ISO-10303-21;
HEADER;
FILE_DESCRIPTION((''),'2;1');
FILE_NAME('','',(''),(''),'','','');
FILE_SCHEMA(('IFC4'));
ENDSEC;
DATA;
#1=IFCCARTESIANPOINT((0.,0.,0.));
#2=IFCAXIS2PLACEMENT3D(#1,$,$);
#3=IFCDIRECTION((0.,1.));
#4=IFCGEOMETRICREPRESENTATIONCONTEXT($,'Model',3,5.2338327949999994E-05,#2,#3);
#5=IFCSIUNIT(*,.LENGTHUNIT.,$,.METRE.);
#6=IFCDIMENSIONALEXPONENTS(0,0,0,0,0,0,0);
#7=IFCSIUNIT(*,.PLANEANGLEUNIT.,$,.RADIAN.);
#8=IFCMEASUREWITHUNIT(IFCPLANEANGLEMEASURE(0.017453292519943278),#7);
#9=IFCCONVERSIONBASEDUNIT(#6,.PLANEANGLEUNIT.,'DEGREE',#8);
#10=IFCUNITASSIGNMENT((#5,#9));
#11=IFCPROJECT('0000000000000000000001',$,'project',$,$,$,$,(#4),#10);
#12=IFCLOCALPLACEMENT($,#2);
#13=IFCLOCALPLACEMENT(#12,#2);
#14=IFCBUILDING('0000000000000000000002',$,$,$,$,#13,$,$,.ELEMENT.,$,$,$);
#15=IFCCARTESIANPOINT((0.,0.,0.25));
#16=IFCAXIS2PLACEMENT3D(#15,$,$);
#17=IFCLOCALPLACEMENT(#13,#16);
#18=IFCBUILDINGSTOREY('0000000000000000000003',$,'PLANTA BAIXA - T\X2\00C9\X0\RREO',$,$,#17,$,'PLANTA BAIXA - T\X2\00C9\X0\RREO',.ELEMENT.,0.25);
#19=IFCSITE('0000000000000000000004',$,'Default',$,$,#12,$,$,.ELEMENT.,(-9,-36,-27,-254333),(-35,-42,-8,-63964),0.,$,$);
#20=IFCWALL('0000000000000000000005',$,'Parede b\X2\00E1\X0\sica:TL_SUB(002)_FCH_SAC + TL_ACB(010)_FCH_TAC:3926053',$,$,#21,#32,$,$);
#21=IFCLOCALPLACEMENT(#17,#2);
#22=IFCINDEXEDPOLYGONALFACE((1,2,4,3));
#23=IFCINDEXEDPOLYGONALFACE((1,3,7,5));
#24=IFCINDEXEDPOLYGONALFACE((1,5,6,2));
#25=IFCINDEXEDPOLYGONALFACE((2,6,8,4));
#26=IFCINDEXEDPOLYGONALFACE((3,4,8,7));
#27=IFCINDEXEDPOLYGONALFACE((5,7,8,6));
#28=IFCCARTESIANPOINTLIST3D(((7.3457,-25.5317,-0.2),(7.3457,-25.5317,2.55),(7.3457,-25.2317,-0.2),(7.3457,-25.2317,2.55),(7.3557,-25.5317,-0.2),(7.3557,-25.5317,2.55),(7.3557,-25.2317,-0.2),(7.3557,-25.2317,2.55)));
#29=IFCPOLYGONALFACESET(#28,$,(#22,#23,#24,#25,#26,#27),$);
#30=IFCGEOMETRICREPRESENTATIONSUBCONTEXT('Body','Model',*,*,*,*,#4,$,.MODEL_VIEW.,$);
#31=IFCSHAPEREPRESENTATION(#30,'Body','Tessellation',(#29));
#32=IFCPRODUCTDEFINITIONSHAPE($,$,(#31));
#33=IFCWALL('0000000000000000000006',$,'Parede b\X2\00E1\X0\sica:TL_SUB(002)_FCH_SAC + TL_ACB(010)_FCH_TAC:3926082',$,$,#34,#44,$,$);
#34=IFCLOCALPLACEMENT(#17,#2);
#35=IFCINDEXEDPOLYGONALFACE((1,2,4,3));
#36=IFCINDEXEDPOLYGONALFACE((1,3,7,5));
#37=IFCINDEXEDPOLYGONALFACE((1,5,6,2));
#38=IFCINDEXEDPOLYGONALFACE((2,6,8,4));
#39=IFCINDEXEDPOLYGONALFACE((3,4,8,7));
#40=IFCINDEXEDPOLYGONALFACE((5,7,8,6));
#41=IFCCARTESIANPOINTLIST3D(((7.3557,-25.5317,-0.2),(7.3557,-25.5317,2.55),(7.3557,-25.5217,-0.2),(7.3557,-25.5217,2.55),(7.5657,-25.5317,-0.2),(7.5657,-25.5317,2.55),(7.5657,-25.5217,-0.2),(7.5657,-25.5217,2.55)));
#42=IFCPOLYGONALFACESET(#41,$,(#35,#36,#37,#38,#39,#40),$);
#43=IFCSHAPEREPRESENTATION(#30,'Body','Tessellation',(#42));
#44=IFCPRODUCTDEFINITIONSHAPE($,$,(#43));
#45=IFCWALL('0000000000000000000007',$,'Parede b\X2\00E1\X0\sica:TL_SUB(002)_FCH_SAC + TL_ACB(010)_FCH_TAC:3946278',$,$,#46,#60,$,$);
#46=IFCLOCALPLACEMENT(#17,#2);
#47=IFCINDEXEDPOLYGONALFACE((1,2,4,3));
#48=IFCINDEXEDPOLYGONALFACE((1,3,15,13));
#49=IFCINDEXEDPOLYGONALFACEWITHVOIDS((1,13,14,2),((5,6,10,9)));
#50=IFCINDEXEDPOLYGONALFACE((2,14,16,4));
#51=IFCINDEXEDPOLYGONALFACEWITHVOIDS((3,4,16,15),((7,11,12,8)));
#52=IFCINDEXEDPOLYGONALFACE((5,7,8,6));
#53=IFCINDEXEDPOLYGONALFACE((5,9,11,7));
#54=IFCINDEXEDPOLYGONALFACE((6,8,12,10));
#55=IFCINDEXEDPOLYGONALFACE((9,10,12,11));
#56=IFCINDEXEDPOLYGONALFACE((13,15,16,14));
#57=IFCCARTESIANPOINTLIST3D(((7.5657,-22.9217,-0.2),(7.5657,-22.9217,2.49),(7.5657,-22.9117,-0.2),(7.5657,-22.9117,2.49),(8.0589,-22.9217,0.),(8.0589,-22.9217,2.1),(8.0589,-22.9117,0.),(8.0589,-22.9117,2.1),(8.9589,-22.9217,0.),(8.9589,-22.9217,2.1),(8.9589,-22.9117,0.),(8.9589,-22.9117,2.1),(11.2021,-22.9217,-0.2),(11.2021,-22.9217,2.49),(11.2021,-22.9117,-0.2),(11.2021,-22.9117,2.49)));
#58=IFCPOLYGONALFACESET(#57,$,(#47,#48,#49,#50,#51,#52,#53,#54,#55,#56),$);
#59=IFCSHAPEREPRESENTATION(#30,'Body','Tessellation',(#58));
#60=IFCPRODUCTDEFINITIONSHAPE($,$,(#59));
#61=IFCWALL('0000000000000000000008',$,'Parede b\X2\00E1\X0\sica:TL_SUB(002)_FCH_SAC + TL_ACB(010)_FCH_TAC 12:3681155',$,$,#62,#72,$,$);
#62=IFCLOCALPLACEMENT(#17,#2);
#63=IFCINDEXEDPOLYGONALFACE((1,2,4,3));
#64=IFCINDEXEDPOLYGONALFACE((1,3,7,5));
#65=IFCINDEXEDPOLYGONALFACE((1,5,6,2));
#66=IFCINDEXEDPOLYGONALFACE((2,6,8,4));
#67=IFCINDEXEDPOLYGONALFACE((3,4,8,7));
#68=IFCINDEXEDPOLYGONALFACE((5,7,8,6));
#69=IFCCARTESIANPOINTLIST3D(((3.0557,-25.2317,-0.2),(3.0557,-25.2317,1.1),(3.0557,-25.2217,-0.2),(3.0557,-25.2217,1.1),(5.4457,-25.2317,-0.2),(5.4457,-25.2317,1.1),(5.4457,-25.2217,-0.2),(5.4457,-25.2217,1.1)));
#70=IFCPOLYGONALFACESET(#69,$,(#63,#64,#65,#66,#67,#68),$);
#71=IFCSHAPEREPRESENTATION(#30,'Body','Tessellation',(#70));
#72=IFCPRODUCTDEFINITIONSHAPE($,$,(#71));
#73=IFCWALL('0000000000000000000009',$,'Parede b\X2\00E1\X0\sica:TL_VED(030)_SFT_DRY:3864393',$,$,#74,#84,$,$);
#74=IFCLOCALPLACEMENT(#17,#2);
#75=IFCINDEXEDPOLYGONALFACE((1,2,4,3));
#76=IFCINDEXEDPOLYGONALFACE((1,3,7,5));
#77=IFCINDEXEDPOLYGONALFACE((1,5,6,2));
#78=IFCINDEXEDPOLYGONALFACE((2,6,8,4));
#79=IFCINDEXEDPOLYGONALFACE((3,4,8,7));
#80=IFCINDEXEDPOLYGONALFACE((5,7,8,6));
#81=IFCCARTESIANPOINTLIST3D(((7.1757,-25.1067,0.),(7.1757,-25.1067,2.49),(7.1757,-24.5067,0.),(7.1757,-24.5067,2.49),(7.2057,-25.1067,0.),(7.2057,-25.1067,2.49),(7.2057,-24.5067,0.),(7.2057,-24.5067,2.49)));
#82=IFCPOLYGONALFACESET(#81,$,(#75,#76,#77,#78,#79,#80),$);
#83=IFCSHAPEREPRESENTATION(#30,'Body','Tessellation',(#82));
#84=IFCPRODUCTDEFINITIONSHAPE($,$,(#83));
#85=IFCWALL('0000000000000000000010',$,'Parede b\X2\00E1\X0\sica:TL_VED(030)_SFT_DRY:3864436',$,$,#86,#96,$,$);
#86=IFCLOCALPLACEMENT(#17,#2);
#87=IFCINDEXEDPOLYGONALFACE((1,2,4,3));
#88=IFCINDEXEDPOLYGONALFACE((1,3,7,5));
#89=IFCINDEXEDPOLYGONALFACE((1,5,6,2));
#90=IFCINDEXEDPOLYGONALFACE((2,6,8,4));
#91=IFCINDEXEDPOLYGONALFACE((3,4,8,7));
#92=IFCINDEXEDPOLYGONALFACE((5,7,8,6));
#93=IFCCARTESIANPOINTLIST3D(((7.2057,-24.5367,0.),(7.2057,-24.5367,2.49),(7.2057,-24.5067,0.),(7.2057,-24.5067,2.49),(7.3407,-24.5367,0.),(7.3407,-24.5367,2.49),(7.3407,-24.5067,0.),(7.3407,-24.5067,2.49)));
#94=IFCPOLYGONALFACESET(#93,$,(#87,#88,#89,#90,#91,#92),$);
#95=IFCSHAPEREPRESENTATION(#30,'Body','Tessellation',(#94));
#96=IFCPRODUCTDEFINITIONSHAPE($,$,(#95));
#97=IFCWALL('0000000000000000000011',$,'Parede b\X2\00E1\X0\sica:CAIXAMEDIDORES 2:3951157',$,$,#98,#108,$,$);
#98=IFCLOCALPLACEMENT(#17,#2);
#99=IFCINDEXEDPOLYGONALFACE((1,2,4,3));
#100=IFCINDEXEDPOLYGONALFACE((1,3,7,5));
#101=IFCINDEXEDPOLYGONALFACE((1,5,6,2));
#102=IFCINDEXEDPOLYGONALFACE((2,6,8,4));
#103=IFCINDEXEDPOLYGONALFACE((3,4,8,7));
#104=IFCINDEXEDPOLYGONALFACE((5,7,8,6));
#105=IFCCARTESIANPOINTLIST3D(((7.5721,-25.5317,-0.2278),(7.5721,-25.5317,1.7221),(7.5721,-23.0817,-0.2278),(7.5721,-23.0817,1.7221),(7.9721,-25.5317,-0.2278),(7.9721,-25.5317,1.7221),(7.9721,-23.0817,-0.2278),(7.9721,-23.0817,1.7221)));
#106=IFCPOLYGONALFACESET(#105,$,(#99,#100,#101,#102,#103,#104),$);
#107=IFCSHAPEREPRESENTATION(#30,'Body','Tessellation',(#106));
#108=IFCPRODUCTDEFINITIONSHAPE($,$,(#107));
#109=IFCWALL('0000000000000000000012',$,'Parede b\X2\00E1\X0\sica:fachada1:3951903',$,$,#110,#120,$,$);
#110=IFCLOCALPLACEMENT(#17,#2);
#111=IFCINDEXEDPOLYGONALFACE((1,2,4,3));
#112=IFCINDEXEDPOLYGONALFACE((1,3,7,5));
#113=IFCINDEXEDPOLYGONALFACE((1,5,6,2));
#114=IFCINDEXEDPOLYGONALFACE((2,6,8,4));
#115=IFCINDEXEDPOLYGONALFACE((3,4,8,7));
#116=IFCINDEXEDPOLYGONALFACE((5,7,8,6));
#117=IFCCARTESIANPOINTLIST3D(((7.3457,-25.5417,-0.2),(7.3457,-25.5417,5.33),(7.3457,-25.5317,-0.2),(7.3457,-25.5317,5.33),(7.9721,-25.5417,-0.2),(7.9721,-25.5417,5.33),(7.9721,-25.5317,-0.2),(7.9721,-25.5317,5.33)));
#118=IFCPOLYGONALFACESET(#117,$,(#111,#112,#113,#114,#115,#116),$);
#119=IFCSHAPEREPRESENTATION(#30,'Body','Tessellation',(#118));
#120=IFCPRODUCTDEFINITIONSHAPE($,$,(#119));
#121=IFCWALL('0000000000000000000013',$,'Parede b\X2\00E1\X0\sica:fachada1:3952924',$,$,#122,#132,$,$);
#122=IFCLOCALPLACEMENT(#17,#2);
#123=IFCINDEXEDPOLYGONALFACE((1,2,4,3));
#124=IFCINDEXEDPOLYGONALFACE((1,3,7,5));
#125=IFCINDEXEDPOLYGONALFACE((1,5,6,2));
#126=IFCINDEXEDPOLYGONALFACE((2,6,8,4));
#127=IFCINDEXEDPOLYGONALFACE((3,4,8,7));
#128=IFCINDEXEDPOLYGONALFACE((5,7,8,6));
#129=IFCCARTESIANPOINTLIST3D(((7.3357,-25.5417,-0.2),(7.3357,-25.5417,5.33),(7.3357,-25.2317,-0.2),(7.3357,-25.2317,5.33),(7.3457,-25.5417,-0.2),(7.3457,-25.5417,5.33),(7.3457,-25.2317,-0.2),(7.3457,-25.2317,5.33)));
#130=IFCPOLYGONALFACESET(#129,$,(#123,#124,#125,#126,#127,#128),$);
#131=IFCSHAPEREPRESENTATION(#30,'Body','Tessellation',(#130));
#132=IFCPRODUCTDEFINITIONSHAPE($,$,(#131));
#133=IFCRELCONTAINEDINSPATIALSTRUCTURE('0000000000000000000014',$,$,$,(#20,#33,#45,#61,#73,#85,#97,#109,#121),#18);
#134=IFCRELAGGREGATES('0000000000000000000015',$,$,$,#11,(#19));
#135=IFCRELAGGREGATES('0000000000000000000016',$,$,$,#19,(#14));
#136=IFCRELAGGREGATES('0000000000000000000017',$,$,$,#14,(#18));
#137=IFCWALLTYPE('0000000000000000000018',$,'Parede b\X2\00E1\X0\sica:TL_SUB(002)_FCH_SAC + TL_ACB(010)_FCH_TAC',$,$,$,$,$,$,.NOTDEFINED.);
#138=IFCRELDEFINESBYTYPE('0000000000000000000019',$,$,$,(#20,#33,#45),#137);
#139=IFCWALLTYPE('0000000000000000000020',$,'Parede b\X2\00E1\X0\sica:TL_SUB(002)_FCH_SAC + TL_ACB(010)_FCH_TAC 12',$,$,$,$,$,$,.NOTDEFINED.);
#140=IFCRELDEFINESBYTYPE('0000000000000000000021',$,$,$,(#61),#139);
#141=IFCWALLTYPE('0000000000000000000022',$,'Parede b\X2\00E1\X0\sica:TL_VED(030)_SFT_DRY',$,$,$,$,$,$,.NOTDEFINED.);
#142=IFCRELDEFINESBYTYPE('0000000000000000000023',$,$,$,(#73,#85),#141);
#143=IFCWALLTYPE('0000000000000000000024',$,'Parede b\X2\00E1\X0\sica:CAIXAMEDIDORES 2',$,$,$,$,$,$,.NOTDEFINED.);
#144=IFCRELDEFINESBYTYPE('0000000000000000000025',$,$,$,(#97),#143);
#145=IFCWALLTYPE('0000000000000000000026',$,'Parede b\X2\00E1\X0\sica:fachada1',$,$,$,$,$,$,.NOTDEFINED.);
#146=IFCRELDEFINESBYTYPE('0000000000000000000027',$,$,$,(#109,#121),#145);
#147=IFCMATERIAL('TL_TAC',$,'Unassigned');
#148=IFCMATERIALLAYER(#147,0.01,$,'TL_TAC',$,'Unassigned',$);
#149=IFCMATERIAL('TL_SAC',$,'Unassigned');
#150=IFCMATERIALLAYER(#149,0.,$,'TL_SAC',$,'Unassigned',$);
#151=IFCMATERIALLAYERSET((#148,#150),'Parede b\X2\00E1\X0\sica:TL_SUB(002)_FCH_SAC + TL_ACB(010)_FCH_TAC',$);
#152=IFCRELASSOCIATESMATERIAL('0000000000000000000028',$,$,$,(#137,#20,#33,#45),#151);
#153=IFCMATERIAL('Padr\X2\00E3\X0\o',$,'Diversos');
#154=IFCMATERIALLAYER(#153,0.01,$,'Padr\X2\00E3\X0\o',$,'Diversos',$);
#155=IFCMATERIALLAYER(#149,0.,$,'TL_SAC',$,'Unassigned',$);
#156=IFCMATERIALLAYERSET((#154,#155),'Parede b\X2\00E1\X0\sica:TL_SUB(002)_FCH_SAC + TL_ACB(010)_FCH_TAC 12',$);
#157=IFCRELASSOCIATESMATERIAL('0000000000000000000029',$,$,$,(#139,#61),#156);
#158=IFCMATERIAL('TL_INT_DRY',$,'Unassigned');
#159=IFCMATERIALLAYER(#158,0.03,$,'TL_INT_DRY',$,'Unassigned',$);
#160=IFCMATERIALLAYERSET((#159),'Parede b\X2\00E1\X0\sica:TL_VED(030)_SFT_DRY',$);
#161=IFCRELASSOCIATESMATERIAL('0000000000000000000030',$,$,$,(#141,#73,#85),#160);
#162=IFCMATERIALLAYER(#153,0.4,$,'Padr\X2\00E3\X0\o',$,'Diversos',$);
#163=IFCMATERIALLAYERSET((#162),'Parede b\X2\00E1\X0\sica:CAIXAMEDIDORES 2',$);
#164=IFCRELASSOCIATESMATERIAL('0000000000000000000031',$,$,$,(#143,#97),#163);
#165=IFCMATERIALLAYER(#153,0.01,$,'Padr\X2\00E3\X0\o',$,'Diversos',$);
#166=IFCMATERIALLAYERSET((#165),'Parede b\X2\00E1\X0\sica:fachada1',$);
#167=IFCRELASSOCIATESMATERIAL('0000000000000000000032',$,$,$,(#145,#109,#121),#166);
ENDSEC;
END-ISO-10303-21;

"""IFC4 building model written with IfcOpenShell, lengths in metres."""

from ifc_helpers import new_model, entity, si_unit, converted_unit, direction, frame, frame_2d, origin, place, context, subcontext, project, spatial, polyline, rectangle, extrude, clip, bounded_halfspace, material, layer, layer_set, layer_usage, type_object, element, save


model = new_model("IFC4")

# Units and contexts
model_context = context("Model", 3, precision=5.2338327949999994e-05, world=origin(), true_north=direction((0.0, 1.0)))
body_context = subcontext(model_context, "Body", "Model", "MODEL_VIEW")
ifc_project = project(units=[si_unit("LENGTHUNIT", "METRE"), converted_unit("PLANEANGLEUNIT", "DEGREE", entity("IfcPlaneAngleMeasure", 0.017453292519943278), si_unit("PLANEANGLEUNIT", "RADIAN"), dimensions=[0, 0, 0, 0, 0, 0, 0])], contexts=[model_context])

# Site, building, storey
site_placement = place(None, frame((0.0, 0.0, 0.0)))
site = spatial("IfcSite", under=ifc_project, at=site_placement, Name="Default", CompositionType="ELEMENT", RefLatitude=(-9, -36, -27, -254333), RefLongitude=(-35, -42, -8, -63964), RefElevation=0.0)
building_placement = place(site_placement, origin())
building = spatial("IfcBuilding", under=site, at=building_placement, CompositionType="ELEMENT")
storey_placement = place(building_placement, frame((0.0, 0.0, 0.25)))
storey = spatial("IfcBuildingStorey", under=building, at=storey_placement, Name="PLANTA BAIXA - TÉRREO", LongName="PLANTA BAIXA - TÉRREO", CompositionType="ELEMENT", Elevation=0.25)

# Shared definitions
ifc_material_1 = material(Name="TL_SAC", Category="Unassigned")

# Shared definitions
ifc_material_2 = material(Name="TL_TAC", Category="Unassigned")
ifc_layer_1 = layer(ifc_material_2, 0.01, Name="TL_TAC", Category="Unassigned")
ifc_layer_2 = layer(ifc_material_1, 0.0, Name="TL_SAC", Category="Unassigned")
ifc_layer_set_1 = layer_set([ifc_layer_1, ifc_layer_2], Name="Parede básica:TL_SUB(002)_FCH_SAC + TL_ACB(010)_FCH_TAC")
wall_type_1 = type_object("IfcWallType", Name="Parede básica:TL_SUB(002)_FCH_SAC + TL_ACB(010)_FCH_TAC", PredefinedType="NOTDEFINED", material=ifc_layer_set_1)

# Walls
ifc_layer_usage_1 = layer_usage(ifc_layer_set_1, "AXIS2", "NEGATIVE", 0.005)
wall_1_placement = place(storey_placement, frame((7.3507, -25.2317, -0.2), z_axis=(0.0, 0.0, 1.0), x_axis=(0.0, -1.0, 0.0)))
element("IfcWall", 1, at=wall_1_placement, inside=storey, type_object=wall_type_1, material=ifc_layer_usage_1, Name="Parede básica:TL_SUB(002)_FCH_SAC + TL_ACB(010)_FCH_TAC:3926053", context=body_context, shape_type="SweptSolid", body=[
    extrude(rectangle(XDim=0.3, YDim=0.01, at=frame_2d((0.15, 0.0), x_axis=(-1.0, 0.0))), origin(), (0.0, 0.0, 1.0), 2.75),
])
ifc_layer_usage_2 = layer_usage(ifc_layer_set_1, "AXIS2", "NEGATIVE", 0.005)
wall_2_placement = place(storey_placement, frame((7.3557, -25.5267, -0.2)))
element("IfcWall", 2, at=wall_2_placement, inside=storey, type_object=wall_type_1, material=ifc_layer_usage_2, Name="Parede básica:TL_SUB(002)_FCH_SAC + TL_ACB(010)_FCH_TAC:3926082", context=body_context, shape_type="SweptSolid", body=[
    extrude(rectangle(XDim=0.21, YDim=0.01, at=frame_2d((0.105, 0.0), x_axis=(-1.0, 0.0))), origin(), (0.0, 0.0, 1.0), 2.75),
])

# Wall, opening
ifc_layer_usage_3 = layer_usage(ifc_layer_set_1, "AXIS2", "POSITIVE", -0.005)
wall_3_placement = place(storey_placement, frame((7.5657, -22.9167, -0.2)))
wall_3 = element("IfcWall", 3, at=wall_3_placement, inside=storey, type_object=wall_type_1, material=ifc_layer_usage_3, Name="Parede básica:TL_SUB(002)_FCH_SAC + TL_ACB(010)_FCH_TAC:3946278", context=body_context, shape_type="Clipping", body=[
    clip(extrude(rectangle(XDim=3.6364, YDim=0.01, at=frame_2d((1.8182, 0.0), x_axis=(-1.0, 0.0))), origin(), (0.0, 0.0, 1.0), 2.69), bounded_halfspace(frame((0.0, -0.005, 2.69), z_axis=(0.0, 0.0, -1.0), x_axis=(0.0, -1.0, 0.0)), True, frame((0.0, -0.005, 2.69)), polyline([(0.0, 0.0), (3.6364, 0.0), (3.6364, 0.01), (0.0, 0.01), (0.0, 0.0)]))),
])
opening_1_placement = place(wall_3_placement, frame((-7.5657, 22.9167, 0.2)))
element("IfcOpeningElement", 4, at=opening_1_placement, cuts=wall_3, PredefinedType="OPENING", context=body_context, shape_type="SweptSolid", body=[
    extrude(rectangle(XDim=2.1, YDim=0.9, at=frame_2d((0.0, 0.0), x_axis=(1.0, 0.0))), frame((8.5089, -24.5957, 1.05), z_axis=(0.0, 1.0, 0.0), x_axis=(0.0, 0.0, 1.0)), (0.0, 0.0, 1.0), 3.048),
])

# Walls
ifc_material_3 = material(Name="Padrão", Category="Diversos")
ifc_layer_3 = layer(ifc_material_3, 0.01, Name="Padrão", Category="Diversos")
ifc_layer_4 = layer(ifc_material_1, 0.0, Name="TL_SAC", Category="Unassigned")
ifc_layer_set_2 = layer_set([ifc_layer_3, ifc_layer_4], Name="Parede básica:TL_SUB(002)_FCH_SAC + TL_ACB(010)_FCH_TAC 12")
ifc_layer_usage_4 = layer_usage(ifc_layer_set_2, "AXIS2", "POSITIVE", -0.005)
wall_type_2 = type_object("IfcWallType", Name="Parede básica:TL_SUB(002)_FCH_SAC + TL_ACB(010)_FCH_TAC 12", PredefinedType="NOTDEFINED", material=ifc_layer_set_2)
wall_4_placement = place(storey_placement, frame((5.4457, -25.2267, -0.2), z_axis=(0.0, 0.0, 1.0), x_axis=(-1.0, 0.0, 0.0)))
element("IfcWall", 5, at=wall_4_placement, inside=storey, type_object=wall_type_2, material=ifc_layer_usage_4, Name="Parede básica:TL_SUB(002)_FCH_SAC + TL_ACB(010)_FCH_TAC 12:3681155", context=body_context, shape_type="SweptSolid", body=[
    extrude(rectangle(XDim=2.39, YDim=0.01, at=frame_2d((1.195, 0.0), x_axis=(-1.0, 0.0))), origin(), (0.0, 0.0, 1.0), 1.3),
])
ifc_material_4 = material(Name="TL_INT_DRY", Category="Unassigned")
ifc_layer_5 = layer(ifc_material_4, 0.03, Name="TL_INT_DRY", Category="Unassigned")
ifc_layer_set_3 = layer_set([ifc_layer_5], Name="Parede básica:TL_VED(030)_SFT_DRY")
ifc_layer_usage_5 = layer_usage(ifc_layer_set_3, "AXIS2", "NEGATIVE", 0.015)
wall_type_3 = type_object("IfcWallType", Name="Parede básica:TL_VED(030)_SFT_DRY", PredefinedType="NOTDEFINED", material=ifc_layer_set_3)
wall_5_placement = place(storey_placement, frame((7.1907, -25.1067, 0.0), z_axis=(0.0, 0.0, 1.0), x_axis=(0.0, 1.0, 0.0)))
element("IfcWall", 6, at=wall_5_placement, inside=storey, type_object=wall_type_3, material=ifc_layer_usage_5, Name="Parede básica:TL_VED(030)_SFT_DRY:3864393", context=body_context, shape_type="SweptSolid", body=[
    extrude(rectangle(XDim=0.6, YDim=0.03, at=frame_2d((0.3, 0.0), x_axis=(-1.0, 0.0))), origin(), (0.0, 0.0, 1.0), 2.49),
])
ifc_layer_usage_6 = layer_usage(ifc_layer_set_3, "AXIS2", "NEGATIVE", 0.015)
wall_6_placement = place(storey_placement, frame((7.2057, -24.5217, 0.0)))
element("IfcWall", 7, at=wall_6_placement, inside=storey, type_object=wall_type_3, material=ifc_layer_usage_6, Name="Parede básica:TL_VED(030)_SFT_DRY:3864436", context=body_context, shape_type="SweptSolid", body=[
    extrude(rectangle(XDim=0.135, YDim=0.03, at=frame_2d((0.0675, 0.0), x_axis=(-1.0, 0.0))), origin(), (0.0, 0.0, 1.0), 2.49),
])
ifc_layer_6 = layer(ifc_material_3, 0.4, Name="Padrão", Category="Diversos")
ifc_layer_set_4 = layer_set([ifc_layer_6], Name="Parede básica:CAIXAMEDIDORES 2")
ifc_layer_usage_7 = layer_usage(ifc_layer_set_4, "AXIS2", "NEGATIVE", 0.2)
wall_type_4 = type_object("IfcWallType", Name="Parede básica:CAIXAMEDIDORES 2", PredefinedType="NOTDEFINED", material=ifc_layer_set_4)
wall_7_placement = place(storey_placement, frame((7.7721, -23.0817, -0.2278), z_axis=(0.0, 0.0, 1.0), x_axis=(0.0, -1.0, 0.0)))
element("IfcWall", 8, at=wall_7_placement, inside=storey, type_object=wall_type_4, material=ifc_layer_usage_7, Name="Parede básica:CAIXAMEDIDORES 2:3951157", context=body_context, shape_type="SweptSolid", body=[
    extrude(rectangle(XDim=2.45, YDim=0.4, at=frame_2d((1.225, 0.0), x_axis=(-1.0, 0.0))), origin(), (0.0, 0.0, 1.0), 1.9499),
])
ifc_layer_7 = layer(ifc_material_3, 0.01, Name="Padrão", Category="Diversos")
ifc_layer_set_5 = layer_set([ifc_layer_7], Name="Parede básica:fachada1")
ifc_layer_usage_8 = layer_usage(ifc_layer_set_5, "AXIS2", "NEGATIVE", 0.005)
wall_type_5 = type_object("IfcWallType", Name="Parede básica:fachada1", PredefinedType="NOTDEFINED", material=ifc_layer_set_5)
wall_8_placement = place(storey_placement, frame((7.3457, -25.5367, -0.2)))
element("IfcWall", 9, at=wall_8_placement, inside=storey, type_object=wall_type_5, material=ifc_layer_usage_8, Name="Parede básica:fachada1:3951903", context=body_context, shape_type="SweptSolid", body=[
    extrude(rectangle(XDim=0.6264, YDim=0.01, at=frame_2d((0.3132, 0.0), x_axis=(-1.0, 0.0))), origin(), (0.0, 0.0, 1.0), 5.53),
])
ifc_layer_usage_9 = layer_usage(ifc_layer_set_5, "AXIS2", "NEGATIVE", 0.005)
wall_9_placement = place(storey_placement, frame((7.3407, -25.2317, -0.2), z_axis=(0.0, 0.0, 1.0), x_axis=(0.0, -1.0, 0.0)))
element("IfcWall", 10, at=wall_9_placement, inside=storey, type_object=wall_type_5, material=ifc_layer_usage_9, Name="Parede básica:fachada1:3952924", context=body_context, shape_type="SweptSolid", body=[
    extrude(rectangle(XDim=0.31, YDim=0.01, at=frame_2d((0.155, 0.0), x_axis=(-1.0, 0.0))), origin(), (0.0, 0.0, 1.0), 5.53),
])

save(model, "model.ifc")
